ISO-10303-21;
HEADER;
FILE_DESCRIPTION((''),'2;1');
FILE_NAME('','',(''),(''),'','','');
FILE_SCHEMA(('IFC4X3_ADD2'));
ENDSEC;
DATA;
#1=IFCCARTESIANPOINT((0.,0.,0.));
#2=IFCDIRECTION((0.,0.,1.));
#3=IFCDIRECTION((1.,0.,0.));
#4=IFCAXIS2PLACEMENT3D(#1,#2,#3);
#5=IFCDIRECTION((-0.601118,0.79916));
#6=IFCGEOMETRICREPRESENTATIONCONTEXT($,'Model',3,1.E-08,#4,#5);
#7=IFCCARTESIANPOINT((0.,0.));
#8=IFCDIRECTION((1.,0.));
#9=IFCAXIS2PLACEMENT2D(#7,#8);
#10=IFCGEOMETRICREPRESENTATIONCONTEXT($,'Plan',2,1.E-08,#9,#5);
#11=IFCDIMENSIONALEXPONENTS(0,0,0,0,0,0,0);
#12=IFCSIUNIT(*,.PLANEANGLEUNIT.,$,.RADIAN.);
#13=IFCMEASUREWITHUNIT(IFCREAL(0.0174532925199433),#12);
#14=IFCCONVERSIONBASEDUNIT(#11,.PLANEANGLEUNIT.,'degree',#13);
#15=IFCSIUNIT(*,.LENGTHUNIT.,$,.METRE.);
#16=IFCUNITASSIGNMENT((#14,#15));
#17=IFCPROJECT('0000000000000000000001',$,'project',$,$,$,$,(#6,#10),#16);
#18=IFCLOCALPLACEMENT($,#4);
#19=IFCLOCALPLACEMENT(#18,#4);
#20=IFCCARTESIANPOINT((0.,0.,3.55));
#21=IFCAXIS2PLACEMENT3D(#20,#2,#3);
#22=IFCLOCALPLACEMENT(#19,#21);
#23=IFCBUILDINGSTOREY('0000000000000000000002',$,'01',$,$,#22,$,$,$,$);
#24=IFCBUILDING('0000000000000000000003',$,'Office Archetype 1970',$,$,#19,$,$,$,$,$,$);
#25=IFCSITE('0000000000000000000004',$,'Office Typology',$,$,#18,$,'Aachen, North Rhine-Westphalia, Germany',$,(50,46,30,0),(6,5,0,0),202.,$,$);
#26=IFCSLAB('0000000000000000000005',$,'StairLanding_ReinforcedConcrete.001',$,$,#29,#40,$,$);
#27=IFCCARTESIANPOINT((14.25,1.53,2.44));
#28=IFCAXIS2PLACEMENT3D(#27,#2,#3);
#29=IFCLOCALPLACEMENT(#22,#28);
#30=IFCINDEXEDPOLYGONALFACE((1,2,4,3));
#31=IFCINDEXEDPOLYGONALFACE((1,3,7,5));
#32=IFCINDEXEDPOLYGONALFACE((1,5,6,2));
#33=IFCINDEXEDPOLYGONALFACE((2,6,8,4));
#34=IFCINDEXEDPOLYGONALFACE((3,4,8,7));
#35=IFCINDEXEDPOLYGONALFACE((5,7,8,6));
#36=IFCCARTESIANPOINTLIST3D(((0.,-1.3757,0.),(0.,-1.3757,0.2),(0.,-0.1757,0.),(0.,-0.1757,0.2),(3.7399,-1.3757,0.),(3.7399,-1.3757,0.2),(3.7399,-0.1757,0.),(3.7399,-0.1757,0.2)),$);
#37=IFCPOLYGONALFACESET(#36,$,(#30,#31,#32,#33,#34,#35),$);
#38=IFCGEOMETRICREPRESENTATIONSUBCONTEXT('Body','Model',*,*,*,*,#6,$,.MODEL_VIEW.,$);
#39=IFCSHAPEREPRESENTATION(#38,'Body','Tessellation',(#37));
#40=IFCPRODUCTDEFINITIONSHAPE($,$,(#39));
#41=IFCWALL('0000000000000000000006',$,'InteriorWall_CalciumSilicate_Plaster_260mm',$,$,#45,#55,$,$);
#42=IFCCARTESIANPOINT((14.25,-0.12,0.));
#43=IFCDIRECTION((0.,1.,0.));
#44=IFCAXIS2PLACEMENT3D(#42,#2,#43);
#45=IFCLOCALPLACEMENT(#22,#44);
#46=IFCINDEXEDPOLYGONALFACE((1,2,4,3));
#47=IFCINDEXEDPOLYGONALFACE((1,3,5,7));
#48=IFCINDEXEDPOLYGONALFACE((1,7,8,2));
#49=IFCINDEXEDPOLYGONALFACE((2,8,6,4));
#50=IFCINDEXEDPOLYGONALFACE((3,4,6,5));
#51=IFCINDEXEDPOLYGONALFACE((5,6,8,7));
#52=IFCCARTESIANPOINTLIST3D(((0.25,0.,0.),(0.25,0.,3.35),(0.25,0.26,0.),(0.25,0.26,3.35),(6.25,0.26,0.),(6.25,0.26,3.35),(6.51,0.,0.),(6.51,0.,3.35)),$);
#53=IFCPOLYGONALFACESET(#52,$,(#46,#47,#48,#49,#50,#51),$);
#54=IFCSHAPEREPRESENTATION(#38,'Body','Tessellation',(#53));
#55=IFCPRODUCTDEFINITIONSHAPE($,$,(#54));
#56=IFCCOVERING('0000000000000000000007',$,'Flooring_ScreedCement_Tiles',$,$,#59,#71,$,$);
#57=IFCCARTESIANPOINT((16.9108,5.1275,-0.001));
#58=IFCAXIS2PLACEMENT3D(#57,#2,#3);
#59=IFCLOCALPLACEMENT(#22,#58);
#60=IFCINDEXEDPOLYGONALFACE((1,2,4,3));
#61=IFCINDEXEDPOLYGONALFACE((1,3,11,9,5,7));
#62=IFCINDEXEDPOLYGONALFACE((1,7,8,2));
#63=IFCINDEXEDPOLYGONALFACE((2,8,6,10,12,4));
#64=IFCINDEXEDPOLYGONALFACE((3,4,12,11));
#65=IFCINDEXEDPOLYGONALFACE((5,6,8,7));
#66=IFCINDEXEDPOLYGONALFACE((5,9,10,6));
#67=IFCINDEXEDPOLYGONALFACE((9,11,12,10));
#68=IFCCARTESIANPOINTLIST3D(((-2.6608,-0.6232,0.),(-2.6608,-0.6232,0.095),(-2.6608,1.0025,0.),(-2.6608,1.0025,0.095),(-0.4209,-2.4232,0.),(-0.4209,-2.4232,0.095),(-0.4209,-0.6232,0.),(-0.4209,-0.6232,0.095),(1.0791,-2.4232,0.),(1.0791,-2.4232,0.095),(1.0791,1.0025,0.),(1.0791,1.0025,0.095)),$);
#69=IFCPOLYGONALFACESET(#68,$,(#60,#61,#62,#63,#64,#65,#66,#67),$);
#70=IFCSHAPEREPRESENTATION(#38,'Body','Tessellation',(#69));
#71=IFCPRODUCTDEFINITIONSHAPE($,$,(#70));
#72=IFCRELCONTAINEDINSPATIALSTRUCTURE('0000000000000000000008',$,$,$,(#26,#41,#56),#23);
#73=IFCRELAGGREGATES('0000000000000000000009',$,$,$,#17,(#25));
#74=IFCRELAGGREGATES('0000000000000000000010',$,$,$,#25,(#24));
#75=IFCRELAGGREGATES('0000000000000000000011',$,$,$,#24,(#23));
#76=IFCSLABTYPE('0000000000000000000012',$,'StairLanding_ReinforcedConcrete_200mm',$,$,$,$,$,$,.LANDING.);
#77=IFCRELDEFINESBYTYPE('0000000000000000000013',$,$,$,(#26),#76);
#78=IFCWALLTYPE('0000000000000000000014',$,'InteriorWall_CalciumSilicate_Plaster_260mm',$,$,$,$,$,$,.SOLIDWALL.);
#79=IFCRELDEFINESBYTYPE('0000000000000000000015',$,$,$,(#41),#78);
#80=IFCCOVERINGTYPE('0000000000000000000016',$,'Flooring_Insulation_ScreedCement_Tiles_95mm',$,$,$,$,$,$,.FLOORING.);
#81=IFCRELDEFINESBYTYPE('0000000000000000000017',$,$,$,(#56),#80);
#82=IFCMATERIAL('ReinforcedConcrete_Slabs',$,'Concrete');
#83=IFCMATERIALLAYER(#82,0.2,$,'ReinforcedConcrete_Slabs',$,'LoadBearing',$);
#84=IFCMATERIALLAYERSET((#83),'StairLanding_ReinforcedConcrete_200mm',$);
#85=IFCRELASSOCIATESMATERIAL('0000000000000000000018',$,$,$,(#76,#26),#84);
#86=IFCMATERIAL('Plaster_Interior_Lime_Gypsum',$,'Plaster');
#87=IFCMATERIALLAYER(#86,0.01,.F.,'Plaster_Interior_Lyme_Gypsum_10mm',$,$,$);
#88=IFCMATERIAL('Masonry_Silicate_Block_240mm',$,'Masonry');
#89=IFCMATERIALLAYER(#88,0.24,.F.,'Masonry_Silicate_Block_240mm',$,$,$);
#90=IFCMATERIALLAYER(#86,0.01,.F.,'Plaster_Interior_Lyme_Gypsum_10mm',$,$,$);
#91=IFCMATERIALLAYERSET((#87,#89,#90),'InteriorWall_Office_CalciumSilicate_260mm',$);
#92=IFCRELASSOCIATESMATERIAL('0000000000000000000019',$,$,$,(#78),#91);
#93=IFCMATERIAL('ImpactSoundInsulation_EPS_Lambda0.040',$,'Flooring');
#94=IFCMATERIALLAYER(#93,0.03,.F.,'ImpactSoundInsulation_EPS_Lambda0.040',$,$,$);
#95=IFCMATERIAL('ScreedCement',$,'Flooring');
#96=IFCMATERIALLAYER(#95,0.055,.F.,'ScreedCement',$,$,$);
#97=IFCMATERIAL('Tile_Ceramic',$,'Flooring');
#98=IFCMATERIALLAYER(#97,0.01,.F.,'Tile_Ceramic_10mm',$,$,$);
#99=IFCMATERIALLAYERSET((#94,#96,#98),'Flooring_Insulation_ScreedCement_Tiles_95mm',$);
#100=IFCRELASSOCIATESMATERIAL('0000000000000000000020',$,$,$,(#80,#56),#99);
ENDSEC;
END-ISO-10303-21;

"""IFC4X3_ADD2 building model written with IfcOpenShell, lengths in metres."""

from ifc_helpers import new_model, entity, si_unit, converted_unit, direction, frame, origin_with_axes, origin_2d_with_axis, place, context, subcontext, project, spatial, line, indexed_curve, outline, extrude, material, layer, layer_set, layer_usage, type_object, element, save


model = new_model("IFC4X3_ADD2")

# Units and contexts
model_context = context("Model", 3, precision=1e-08, world=origin_with_axes(), true_north=direction((-0.601118, 0.79916)))
plan_context = context("Plan", 2, precision=1e-08, world=origin_2d_with_axis(), true_north=direction((-0.601118, 0.79916)))
body_context = subcontext(model_context, "Body", "Model", "MODEL_VIEW")
ifc_project = project(units=[converted_unit("PLANEANGLEUNIT", "degree", entity("IfcReal", 0.0174532925199433), si_unit("PLANEANGLEUNIT", "RADIAN"), dimensions=[0, 0, 0, 0, 0, 0, 0]), si_unit("LENGTHUNIT", "METRE")], contexts=[model_context, plan_context])

# Site, building, storey
site_placement = place(None, origin_with_axes())
site = spatial("IfcSite", under=ifc_project, at=site_placement, Name="Office Typology", LongName="Aachen, North Rhine-Westphalia, Germany", RefLatitude=(50, 46, 30, 0), RefLongitude=(6, 5, 0, 0), RefElevation=202.0)
building_placement = place(site_placement, origin_with_axes())
building = spatial("IfcBuilding", under=site, at=building_placement, Name="Office Archetype 1970")
storey_placement = place(building_placement, frame((0.0, 0.0, 3.55), z_axis=(0.0, 0.0, 1.0), x_axis=(1.0, 0.0, 0.0)))
storey = spatial("IfcBuildingStorey", under=building, at=storey_placement, Name="01")

# Slab
ifc_material_1 = material(Name="ReinforcedConcrete_Slabs", Category="Concrete")
ifc_layer_1 = layer(ifc_material_1, 0.2, Name="ReinforcedConcrete_Slabs", Category="LoadBearing")
ifc_layer_set_1 = layer_set([ifc_layer_1], Name="StairLanding_ReinforcedConcrete_200mm")
ifc_layer_usage_1 = layer_usage(ifc_layer_set_1, "AXIS3", "POSITIVE", 0.0)
slab_type_1 = type_object("IfcSlabType", Name="StairLanding_ReinforcedConcrete_200mm", PredefinedType="LANDING", material=ifc_layer_set_1)
slab_1_placement = place(storey_placement, frame((14.25, 1.53, 2.44), z_axis=(0.0, 0.0, 1.0), x_axis=(1.0, 0.0, 0.0)))
element("IfcSlab", 1, at=slab_1_placement, inside=storey, type_object=slab_type_1, material=ifc_layer_usage_1, Name="StairLanding_ReinforcedConcrete.001", context=body_context, shape_type="SweptSolid", body=[
    extrude(outline(indexed_curve([(3.7399, -0.1757), (3.7399, -1.3757), (0.0, -1.3757), (0.0, -0.1757), (3.7399, -0.1757)])), None, (0.0, 0.0, 1.0), 0.2),
])

# Wall
ifc_material_2 = material(Name="Plaster_Interior_Lime_Gypsum", Category="Plaster")
ifc_layer_2 = layer(ifc_material_2, 0.01, ventilated=False, Name="Plaster_Interior_Lyme_Gypsum_10mm")
ifc_material_3 = material(Name="Masonry_Silicate_Block_240mm", Category="Masonry")
ifc_layer_3 = layer(ifc_material_3, 0.24, ventilated=False, Name="Masonry_Silicate_Block_240mm")
ifc_layer_4 = layer(ifc_material_2, 0.01, ventilated=False, Name="Plaster_Interior_Lyme_Gypsum_10mm")
ifc_layer_set_2 = layer_set([ifc_layer_2, ifc_layer_3, ifc_layer_4], Name="InteriorWall_Office_CalciumSilicate_260mm")
wall_type = type_object("IfcWallType", Name="InteriorWall_CalciumSilicate_Plaster_260mm", PredefinedType="SOLIDWALL", material=ifc_layer_set_2)
wall_placement = place(storey_placement, frame((14.25, -0.12, 0.0), z_axis=(0.0, 0.0, 1.0), x_axis=(0.0, 1.0, 0.0)))
element("IfcWall", 2, at=wall_placement, inside=storey, type_object=wall_type, Name="InteriorWall_CalciumSilicate_Plaster_260mm", context=body_context, shape_type="SweptSolid", body=[
    extrude(outline(indexed_curve([(0.25, 0.0), (0.25, 0.26), (6.25, 0.26), (6.51, 0.0)], segments=[line(1, 2, 3, 4, 1)])), origin_with_axes(), (0.0, 0.0, 1.0), 3.35),
])

# Covering
ifc_material_4 = material(Name="ImpactSoundInsulation_EPS_Lambda0.040", Category="Flooring")
ifc_layer_5 = layer(ifc_material_4, 0.03, ventilated=False, Name="ImpactSoundInsulation_EPS_Lambda0.040")
ifc_material_5 = material(Name="ScreedCement", Category="Flooring")
ifc_layer_6 = layer(ifc_material_5, 0.055, ventilated=False, Name="ScreedCement")
ifc_material_6 = material(Name="Tile_Ceramic", Category="Flooring")
ifc_layer_7 = layer(ifc_material_6, 0.01, ventilated=False, Name="Tile_Ceramic_10mm")
ifc_layer_set_3 = layer_set([ifc_layer_5, ifc_layer_6, ifc_layer_7], Name="Flooring_Insulation_ScreedCement_Tiles_95mm")
ifc_layer_usage_2 = layer_usage(ifc_layer_set_3, "AXIS3", "POSITIVE", 0.0)
covering_type = type_object("IfcCoveringType", Name="Flooring_Insulation_ScreedCement_Tiles_95mm", PredefinedType="FLOORING", material=ifc_layer_set_3)
covering_placement = place(storey_placement, frame((16.9108, 5.1275, -0.001), z_axis=(0.0, 0.0, 1.0), x_axis=(1.0, 0.0, 0.0)))
element("IfcCovering", 3, at=covering_placement, inside=storey, type_object=covering_type, material=ifc_layer_usage_2, Name="Flooring_ScreedCement_Tiles", context=body_context, shape_type="SweptSolid", body=[
    extrude(outline(indexed_curve([(-2.6608, 1.0025), (-2.6608, -0.6232), (-0.4209, -0.6232), (-0.4209, -2.4232), (1.0791, -2.4232), (1.0791, 1.0025)], segments=[line(1, 2, 3, 4, 5, 6, 1)])), None, (0.0, 0.0, 1.0), 0.095),
])

save(model, "model.ifc")
